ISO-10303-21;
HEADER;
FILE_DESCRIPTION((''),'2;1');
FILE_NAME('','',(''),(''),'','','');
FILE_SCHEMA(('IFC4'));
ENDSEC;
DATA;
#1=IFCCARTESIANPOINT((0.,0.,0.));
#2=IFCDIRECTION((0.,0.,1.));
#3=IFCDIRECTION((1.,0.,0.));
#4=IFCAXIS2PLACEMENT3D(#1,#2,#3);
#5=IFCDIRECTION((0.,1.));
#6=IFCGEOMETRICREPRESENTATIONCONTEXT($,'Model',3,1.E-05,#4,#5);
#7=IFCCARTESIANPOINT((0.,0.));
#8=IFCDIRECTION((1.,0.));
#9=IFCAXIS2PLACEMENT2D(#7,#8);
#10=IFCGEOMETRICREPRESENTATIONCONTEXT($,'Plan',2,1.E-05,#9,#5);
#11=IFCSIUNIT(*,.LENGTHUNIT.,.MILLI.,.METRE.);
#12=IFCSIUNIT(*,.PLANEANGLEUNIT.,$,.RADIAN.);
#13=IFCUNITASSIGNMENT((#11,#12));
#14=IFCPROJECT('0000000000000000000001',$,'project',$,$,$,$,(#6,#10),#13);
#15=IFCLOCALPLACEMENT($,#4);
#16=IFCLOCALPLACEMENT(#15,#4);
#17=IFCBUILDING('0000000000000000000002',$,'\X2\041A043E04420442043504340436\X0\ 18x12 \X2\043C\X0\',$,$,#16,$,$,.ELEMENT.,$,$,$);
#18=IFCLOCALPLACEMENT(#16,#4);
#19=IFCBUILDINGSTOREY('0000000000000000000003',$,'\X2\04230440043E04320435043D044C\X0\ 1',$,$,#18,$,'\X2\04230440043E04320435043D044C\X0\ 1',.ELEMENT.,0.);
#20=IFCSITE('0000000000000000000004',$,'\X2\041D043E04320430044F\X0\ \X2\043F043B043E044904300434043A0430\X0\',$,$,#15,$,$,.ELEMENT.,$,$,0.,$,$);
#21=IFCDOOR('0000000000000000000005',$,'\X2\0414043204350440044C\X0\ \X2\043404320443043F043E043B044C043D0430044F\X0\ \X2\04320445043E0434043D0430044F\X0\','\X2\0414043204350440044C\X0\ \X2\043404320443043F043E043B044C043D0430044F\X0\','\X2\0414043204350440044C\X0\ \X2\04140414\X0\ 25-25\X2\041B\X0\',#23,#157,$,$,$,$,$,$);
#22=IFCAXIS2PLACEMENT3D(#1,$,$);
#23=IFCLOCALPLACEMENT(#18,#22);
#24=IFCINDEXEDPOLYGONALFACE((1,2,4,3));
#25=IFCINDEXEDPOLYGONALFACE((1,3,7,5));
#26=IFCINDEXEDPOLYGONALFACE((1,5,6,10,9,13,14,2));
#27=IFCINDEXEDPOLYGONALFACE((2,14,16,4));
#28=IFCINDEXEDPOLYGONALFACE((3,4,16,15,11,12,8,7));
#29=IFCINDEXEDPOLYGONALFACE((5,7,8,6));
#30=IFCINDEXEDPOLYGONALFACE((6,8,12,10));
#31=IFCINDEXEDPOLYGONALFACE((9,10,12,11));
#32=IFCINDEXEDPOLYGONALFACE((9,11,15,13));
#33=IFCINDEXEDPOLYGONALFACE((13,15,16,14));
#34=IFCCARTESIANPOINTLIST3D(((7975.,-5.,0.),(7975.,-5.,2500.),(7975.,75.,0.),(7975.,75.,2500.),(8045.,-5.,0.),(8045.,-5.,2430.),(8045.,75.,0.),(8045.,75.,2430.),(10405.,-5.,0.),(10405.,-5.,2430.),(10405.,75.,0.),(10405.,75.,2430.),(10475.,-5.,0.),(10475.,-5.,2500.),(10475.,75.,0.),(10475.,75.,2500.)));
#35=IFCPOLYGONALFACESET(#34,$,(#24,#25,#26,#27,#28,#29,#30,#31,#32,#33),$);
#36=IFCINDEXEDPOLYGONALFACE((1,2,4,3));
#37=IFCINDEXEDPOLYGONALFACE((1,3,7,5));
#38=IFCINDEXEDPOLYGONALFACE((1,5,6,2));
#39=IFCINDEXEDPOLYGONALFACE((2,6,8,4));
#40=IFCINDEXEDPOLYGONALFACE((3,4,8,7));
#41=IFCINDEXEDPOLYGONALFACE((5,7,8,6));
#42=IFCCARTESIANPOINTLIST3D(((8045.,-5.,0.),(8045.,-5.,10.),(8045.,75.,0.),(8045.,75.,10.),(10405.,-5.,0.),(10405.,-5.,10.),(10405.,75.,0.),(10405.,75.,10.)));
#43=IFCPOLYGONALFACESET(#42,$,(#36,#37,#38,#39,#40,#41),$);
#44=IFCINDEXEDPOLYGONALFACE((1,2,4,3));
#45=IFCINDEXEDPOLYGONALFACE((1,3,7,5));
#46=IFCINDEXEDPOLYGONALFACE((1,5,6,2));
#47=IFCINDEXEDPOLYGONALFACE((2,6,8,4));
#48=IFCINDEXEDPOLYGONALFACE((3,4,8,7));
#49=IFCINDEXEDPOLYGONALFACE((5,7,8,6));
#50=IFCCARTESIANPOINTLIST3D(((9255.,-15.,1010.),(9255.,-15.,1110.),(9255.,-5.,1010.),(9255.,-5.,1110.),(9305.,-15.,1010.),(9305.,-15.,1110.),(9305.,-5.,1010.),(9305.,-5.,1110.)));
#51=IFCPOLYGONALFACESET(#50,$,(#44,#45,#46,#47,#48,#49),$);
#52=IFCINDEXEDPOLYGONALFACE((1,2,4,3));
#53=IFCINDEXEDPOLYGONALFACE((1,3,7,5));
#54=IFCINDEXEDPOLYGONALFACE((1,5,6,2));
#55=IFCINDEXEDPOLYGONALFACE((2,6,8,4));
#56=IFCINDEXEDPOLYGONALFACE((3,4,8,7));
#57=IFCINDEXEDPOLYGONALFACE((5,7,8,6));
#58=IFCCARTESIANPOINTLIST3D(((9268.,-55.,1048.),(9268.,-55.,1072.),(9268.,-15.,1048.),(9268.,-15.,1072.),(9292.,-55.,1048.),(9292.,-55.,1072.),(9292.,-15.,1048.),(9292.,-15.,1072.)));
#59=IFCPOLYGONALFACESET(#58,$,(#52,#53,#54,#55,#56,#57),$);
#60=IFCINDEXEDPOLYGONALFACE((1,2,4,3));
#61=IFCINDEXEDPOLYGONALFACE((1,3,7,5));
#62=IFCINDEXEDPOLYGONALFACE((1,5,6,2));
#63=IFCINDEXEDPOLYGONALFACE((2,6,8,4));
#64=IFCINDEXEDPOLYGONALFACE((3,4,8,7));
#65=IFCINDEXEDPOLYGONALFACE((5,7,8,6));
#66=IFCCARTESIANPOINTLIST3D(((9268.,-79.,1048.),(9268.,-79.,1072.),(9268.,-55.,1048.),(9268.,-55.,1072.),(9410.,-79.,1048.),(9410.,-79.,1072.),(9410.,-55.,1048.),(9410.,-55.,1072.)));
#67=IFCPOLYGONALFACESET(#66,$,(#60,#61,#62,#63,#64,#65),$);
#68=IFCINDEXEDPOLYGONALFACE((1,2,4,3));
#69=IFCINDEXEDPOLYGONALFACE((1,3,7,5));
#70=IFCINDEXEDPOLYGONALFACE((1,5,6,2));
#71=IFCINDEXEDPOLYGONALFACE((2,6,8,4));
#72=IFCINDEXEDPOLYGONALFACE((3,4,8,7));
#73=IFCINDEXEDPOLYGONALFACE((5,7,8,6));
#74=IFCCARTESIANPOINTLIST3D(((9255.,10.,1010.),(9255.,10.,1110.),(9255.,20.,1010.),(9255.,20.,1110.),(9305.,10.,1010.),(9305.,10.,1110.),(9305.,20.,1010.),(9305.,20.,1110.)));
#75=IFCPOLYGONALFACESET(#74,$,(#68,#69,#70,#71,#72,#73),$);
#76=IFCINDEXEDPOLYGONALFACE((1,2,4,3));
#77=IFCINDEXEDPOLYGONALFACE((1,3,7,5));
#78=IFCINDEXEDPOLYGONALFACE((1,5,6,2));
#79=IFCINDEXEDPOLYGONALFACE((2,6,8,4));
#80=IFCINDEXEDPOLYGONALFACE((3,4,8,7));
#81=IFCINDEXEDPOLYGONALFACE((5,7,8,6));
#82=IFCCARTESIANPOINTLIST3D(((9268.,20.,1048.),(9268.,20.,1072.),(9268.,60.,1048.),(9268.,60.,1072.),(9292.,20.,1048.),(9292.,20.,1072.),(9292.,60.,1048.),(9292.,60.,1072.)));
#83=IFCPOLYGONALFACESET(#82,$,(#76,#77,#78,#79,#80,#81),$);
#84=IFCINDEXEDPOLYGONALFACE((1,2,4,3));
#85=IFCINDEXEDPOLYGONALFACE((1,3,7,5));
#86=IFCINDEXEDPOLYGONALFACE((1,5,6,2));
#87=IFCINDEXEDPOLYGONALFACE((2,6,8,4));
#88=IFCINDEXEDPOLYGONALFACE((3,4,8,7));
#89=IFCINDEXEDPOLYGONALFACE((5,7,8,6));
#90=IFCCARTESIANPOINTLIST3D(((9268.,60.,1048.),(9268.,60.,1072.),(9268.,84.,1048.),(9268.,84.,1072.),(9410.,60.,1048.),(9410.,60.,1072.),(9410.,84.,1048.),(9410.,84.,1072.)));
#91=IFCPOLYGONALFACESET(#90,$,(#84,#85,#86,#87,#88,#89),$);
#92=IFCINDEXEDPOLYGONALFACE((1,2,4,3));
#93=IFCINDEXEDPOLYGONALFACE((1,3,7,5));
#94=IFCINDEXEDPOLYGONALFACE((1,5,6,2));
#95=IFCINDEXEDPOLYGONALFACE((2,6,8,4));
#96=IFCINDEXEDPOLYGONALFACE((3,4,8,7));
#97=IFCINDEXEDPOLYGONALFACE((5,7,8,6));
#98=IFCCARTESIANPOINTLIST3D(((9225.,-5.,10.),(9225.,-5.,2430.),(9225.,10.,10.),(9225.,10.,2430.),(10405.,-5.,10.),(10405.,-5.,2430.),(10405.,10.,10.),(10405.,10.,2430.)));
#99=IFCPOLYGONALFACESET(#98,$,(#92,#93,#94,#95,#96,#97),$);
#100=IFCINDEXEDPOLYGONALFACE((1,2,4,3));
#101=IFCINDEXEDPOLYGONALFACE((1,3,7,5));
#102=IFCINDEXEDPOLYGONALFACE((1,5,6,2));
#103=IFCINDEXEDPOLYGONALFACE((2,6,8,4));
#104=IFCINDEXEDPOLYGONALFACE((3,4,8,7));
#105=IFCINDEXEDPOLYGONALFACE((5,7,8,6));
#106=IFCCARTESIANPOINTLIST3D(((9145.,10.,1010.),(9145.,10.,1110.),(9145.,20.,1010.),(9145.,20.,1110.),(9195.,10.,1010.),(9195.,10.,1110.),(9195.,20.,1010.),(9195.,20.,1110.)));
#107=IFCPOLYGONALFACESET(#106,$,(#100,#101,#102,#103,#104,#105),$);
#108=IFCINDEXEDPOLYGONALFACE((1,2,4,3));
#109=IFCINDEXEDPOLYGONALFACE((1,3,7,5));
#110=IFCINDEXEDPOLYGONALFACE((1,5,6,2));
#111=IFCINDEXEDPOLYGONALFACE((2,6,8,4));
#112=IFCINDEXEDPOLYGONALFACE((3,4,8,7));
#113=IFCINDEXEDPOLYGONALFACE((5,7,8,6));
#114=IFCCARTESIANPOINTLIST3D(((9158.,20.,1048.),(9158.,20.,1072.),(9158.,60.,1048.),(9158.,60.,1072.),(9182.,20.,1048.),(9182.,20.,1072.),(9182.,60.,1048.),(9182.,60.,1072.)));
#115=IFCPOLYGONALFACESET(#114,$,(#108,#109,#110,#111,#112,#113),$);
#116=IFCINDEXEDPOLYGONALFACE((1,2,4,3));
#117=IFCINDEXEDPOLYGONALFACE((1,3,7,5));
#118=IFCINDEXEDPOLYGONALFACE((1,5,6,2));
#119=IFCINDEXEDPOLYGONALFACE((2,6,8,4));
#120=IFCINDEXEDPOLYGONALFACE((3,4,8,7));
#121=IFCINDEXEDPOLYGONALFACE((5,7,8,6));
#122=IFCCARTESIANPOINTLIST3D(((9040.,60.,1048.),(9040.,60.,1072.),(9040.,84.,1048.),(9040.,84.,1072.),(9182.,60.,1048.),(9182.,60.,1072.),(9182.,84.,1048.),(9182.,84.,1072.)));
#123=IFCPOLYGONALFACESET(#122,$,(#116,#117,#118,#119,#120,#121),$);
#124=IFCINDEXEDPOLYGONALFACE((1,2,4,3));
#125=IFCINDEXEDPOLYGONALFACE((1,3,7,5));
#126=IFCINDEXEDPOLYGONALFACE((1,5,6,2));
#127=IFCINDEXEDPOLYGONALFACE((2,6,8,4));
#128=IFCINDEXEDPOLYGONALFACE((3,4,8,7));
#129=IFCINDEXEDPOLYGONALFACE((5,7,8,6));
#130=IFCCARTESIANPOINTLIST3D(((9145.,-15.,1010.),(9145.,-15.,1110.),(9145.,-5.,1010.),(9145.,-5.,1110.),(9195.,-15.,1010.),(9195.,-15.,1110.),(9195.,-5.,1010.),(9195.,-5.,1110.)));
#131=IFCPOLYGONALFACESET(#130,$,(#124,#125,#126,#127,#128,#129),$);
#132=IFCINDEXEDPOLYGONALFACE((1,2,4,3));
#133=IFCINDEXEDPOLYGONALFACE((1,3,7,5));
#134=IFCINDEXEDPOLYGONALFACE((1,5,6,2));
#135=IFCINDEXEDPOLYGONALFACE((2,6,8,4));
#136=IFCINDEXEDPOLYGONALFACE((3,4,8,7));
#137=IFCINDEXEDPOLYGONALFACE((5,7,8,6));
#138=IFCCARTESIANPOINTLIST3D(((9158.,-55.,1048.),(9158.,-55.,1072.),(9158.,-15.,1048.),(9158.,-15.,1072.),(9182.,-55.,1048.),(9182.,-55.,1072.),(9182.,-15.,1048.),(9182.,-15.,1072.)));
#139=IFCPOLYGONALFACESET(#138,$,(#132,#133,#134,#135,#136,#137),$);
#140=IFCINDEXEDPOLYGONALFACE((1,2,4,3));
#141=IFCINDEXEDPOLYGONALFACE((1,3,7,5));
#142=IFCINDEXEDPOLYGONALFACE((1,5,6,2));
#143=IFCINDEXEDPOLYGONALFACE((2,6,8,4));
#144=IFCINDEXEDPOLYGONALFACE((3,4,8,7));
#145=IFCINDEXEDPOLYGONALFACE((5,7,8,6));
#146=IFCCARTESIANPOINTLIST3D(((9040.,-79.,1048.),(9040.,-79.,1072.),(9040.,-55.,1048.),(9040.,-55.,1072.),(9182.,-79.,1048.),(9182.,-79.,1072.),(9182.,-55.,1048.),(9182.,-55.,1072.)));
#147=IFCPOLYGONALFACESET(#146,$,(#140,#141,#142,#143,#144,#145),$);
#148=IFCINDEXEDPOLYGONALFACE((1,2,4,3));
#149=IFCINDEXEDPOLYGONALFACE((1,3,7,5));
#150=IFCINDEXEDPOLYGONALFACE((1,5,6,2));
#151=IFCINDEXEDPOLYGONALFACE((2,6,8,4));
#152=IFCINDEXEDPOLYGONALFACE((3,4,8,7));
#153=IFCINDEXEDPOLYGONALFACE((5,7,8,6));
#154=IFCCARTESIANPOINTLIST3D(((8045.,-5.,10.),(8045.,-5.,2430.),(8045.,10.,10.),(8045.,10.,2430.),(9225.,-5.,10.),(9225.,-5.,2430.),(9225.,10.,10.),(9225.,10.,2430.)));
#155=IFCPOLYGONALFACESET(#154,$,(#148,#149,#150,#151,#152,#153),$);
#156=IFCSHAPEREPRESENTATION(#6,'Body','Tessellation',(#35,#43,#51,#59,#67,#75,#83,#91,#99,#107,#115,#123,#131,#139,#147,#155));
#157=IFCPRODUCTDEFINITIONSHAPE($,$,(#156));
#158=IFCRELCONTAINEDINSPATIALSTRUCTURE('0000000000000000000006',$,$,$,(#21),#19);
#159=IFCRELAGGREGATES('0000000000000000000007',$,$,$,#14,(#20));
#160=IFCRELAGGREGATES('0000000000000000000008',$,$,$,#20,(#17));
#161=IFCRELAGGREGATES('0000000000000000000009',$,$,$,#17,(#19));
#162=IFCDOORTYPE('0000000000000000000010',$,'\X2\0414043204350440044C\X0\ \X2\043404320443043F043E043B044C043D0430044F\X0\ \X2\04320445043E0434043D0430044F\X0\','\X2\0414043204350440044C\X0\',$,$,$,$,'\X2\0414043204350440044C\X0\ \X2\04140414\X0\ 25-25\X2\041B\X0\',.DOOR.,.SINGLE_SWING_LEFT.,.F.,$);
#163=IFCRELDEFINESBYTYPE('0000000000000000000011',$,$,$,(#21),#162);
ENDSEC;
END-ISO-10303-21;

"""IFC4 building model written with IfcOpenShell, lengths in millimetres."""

from ifc_helpers import new_model, si_unit, direction, frame, origin_with_axes, origin_2d_with_axis, place, context, project, spatial, polyline, segment, composite_curve, rectangle, outline, extrude, boolean, type_object, element, save


model = new_model("IFC4")

# Units and contexts
model_context = context("Model", 3, precision=1e-05, world=origin_with_axes(), true_north=direction((0.0, 1.0)))
plan_context = context("Plan", 2, precision=1e-05, world=origin_2d_with_axis(), true_north=direction((0.0, 1.0)))
ifc_project = project(units=[si_unit("LENGTHUNIT", "METRE", prefix="MILLI"), si_unit("PLANEANGLEUNIT", "RADIAN")], contexts=[model_context, plan_context])

# Site, building, storey
site_placement = place(None, origin_with_axes())
site = spatial("IfcSite", under=ifc_project, at=site_placement, Name="Новая площадка", CompositionType="ELEMENT", RefElevation=0.0)
building_placement = place(site_placement, origin_with_axes())
building = spatial("IfcBuilding", under=site, at=building_placement, Name="Коттедж 18x12 м", CompositionType="ELEMENT")
storey_placement = place(building_placement, origin_with_axes())
storey = spatial("IfcBuildingStorey", under=building, at=storey_placement, Name="Уровень 1", LongName="Уровень 1", CompositionType="ELEMENT", Elevation=0.0)

# Door
door_type = type_object("IfcDoorType", Name="Дверь двупольная входная", Description="Дверь", ElementType="Дверь ДД 25-25Л", OperationType="SINGLE_SWING_LEFT", ParameterTakesPrecedence=False, PredefinedType="DOOR")
door_placement = place(None, frame((7975.0, 0.0, 0.0), z_axis=(0.0, 0.0, 1.0), x_axis=(1.0, 0.0, 0.0)))
element("IfcDoor", 1, at=door_placement, inside=storey, type_object=door_type, Name="Дверь двупольная входная", Description="Дверь двупольная", ObjectType="Дверь ДД 25-25Л", context=model_context, shape_type="SweptSolid", body=[
    boolean("DIFFERENCE", extrude(outline(composite_curve([segment(polyline([(0.0, 0.0), (0.0, -2500.0)]), True, "CONTINUOUS"), segment(polyline([(0.0, -2500.0), (2500.0, -2500.0)]), True, "CONTINUOUS"), segment(polyline([(2500.0, -2500.0), (2500.0, 0.0)]), True, "CONTINUOUS"), segment(polyline([(2500.0, 0.0), (0.0, 0.0)]), True, "DISCONTINUOUS")], self_intersect=False)), frame((2500.0, -5.0, 0.0), z_axis=(0.0, 1.0, 0.0), x_axis=(0.0, 0.0, 1.0)), (0.0, 0.0, 1.0), 80.0), extrude(outline(composite_curve([segment(polyline([(0.0, -70.0), (0.0, -2430.0)]), True, "CONTINUOUS"), segment(polyline([(0.0, -2430.0), (2430.0, -2430.0)]), True, "CONTINUOUS"), segment(polyline([(2430.0, -2430.0), (2430.0, -70.0)]), True, "CONTINUOUS"), segment(polyline([(2430.0, -70.0), (0.0, -70.0)]), True, "DISCONTINUOUS")], self_intersect=False)), frame((2500.0, -5.0, 0.0), z_axis=(0.0, 1.0, 0.0), x_axis=(0.0, 0.0, 1.0)), (0.0, 0.0, 1.0), 80.0)),
    extrude(rectangle(XDim=2360.0, YDim=80.0, at=origin_2d_with_axis()), frame((1250.0, 35.0, 0.0), z_axis=(0.0, 0.0, 1.0), x_axis=(-1.0, 0.0, 0.0)), (0.0, 0.0, 1.0), 10.0),
    extrude(rectangle(XDim=50.0, YDim=10.0, at=origin_2d_with_axis()), frame((1305.0, -10.0, 1010.0), z_axis=(0.0, 0.0, 1.0), x_axis=(-1.0, 0.0, 0.0)), (0.0, 0.0, 1.0), 100.0),
    extrude(rectangle(XDim=24.0, YDim=40.0, at=origin_2d_with_axis()), frame((1305.0, -35.0, 1048.0), z_axis=(0.0, 0.0, 1.0), x_axis=(-1.0, 0.0, 0.0)), (0.0, 0.0, 1.0), 24.0),
    extrude(rectangle(XDim=142.0, YDim=24.0, at=origin_2d_with_axis()), frame((1364.0, -67.0, 1048.0), z_axis=(0.0, 0.0, 1.0), x_axis=(1.0, 0.0, 0.0)), (0.0, 0.0, 1.0), 24.0),
    extrude(rectangle(XDim=50.0, YDim=10.0, at=origin_2d_with_axis()), frame((1305.0, 15.0, 1110.0), z_axis=(0.0, 0.0, -1.0), x_axis=(-1.0, 0.0, 0.0)), (0.0, 0.0, 1.0), 100.0),
    extrude(rectangle(XDim=24.0, YDim=40.0, at=origin_2d_with_axis()), frame((1305.0, 40.0, 1072.0), z_axis=(0.0, 0.0, -1.0), x_axis=(-1.0, 0.0, 0.0)), (0.0, 0.0, 1.0), 24.0),
    extrude(rectangle(XDim=142.0, YDim=24.0, at=origin_2d_with_axis()), frame((1364.0, 72.0, 1072.0), z_axis=(0.0, 0.0, -1.0), x_axis=(1.0, 0.0, 0.0)), (0.0, 0.0, 1.0), 24.0),
    extrude(outline(composite_curve([segment(polyline([(0.0, 0.0), (0.0, -1180.0)]), True, "CONTINUOUS"), segment(polyline([(0.0, -1180.0), (2420.0, -1180.0)]), True, "CONTINUOUS"), segment(polyline([(2420.0, -1180.0), (2420.0, 0.0)]), True, "CONTINUOUS"), segment(polyline([(2420.0, 0.0), (0.0, 0.0)]), True, "DISCONTINUOUS")], self_intersect=False)), frame((2430.0, -5.0, 10.0), z_axis=(0.0, 1.0, 0.0), x_axis=(0.0, 0.0, 1.0)), (0.0, 0.0, 1.0), 15.0),
    extrude(rectangle(XDim=50.0, YDim=10.0, at=origin_2d_with_axis()), frame((1195.0, 15.0, 1010.0), z_axis=(0.0, 0.0, 1.0), x_axis=(1.0, 0.0, 0.0)), (0.0, 0.0, 1.0), 100.0),
    extrude(rectangle(XDim=24.0, YDim=40.0, at=origin_2d_with_axis()), frame((1195.0, 40.0, 1048.0), z_axis=(0.0, 0.0, 1.0), x_axis=(1.0, 0.0, 0.0)), (0.0, 0.0, 1.0), 24.0),
    extrude(rectangle(XDim=142.0, YDim=24.0, at=origin_2d_with_axis()), frame((1136.0, 72.0, 1048.0), z_axis=(0.0, 0.0, 1.0), x_axis=(-1.0, 0.0, 0.0)), (0.0, 0.0, 1.0), 24.0),
    extrude(rectangle(XDim=50.0, YDim=10.0, at=origin_2d_with_axis()), frame((1195.0, -10.0, 1110.0), z_axis=(0.0, 0.0, -1.0), x_axis=(1.0, 0.0, 0.0)), (0.0, 0.0, 1.0), 100.0),
    extrude(rectangle(XDim=24.0, YDim=40.0, at=origin_2d_with_axis()), frame((1195.0, -35.0, 1072.0), z_axis=(0.0, 0.0, -1.0), x_axis=(1.0, 0.0, 0.0)), (0.0, 0.0, 1.0), 24.0),
    extrude(rectangle(XDim=142.0, YDim=24.0, at=origin_2d_with_axis()), frame((1136.0, -67.0, 1072.0), z_axis=(0.0, 0.0, -1.0), x_axis=(-1.0, 0.0, 0.0)), (0.0, 0.0, 1.0), 24.0),
    extrude(outline(composite_curve([segment(polyline([(0.0, 0.0), (0.0, -1180.0)]), True, "CONTINUOUS"), segment(polyline([(0.0, -1180.0), (2420.0, -1180.0)]), True, "CONTINUOUS"), segment(polyline([(2420.0, -1180.0), (2420.0, 0.0)]), True, "CONTINUOUS"), segment(polyline([(2420.0, 0.0), (0.0, 0.0)]), True, "DISCONTINUOUS")], self_intersect=False)), frame((70.0, 10.0, 10.0), z_axis=(0.0, -1.0, 0.0), x_axis=(0.0, 0.0, 1.0)), (0.0, 0.0, 1.0), 15.0),
])

save(model, "model.ifc")
